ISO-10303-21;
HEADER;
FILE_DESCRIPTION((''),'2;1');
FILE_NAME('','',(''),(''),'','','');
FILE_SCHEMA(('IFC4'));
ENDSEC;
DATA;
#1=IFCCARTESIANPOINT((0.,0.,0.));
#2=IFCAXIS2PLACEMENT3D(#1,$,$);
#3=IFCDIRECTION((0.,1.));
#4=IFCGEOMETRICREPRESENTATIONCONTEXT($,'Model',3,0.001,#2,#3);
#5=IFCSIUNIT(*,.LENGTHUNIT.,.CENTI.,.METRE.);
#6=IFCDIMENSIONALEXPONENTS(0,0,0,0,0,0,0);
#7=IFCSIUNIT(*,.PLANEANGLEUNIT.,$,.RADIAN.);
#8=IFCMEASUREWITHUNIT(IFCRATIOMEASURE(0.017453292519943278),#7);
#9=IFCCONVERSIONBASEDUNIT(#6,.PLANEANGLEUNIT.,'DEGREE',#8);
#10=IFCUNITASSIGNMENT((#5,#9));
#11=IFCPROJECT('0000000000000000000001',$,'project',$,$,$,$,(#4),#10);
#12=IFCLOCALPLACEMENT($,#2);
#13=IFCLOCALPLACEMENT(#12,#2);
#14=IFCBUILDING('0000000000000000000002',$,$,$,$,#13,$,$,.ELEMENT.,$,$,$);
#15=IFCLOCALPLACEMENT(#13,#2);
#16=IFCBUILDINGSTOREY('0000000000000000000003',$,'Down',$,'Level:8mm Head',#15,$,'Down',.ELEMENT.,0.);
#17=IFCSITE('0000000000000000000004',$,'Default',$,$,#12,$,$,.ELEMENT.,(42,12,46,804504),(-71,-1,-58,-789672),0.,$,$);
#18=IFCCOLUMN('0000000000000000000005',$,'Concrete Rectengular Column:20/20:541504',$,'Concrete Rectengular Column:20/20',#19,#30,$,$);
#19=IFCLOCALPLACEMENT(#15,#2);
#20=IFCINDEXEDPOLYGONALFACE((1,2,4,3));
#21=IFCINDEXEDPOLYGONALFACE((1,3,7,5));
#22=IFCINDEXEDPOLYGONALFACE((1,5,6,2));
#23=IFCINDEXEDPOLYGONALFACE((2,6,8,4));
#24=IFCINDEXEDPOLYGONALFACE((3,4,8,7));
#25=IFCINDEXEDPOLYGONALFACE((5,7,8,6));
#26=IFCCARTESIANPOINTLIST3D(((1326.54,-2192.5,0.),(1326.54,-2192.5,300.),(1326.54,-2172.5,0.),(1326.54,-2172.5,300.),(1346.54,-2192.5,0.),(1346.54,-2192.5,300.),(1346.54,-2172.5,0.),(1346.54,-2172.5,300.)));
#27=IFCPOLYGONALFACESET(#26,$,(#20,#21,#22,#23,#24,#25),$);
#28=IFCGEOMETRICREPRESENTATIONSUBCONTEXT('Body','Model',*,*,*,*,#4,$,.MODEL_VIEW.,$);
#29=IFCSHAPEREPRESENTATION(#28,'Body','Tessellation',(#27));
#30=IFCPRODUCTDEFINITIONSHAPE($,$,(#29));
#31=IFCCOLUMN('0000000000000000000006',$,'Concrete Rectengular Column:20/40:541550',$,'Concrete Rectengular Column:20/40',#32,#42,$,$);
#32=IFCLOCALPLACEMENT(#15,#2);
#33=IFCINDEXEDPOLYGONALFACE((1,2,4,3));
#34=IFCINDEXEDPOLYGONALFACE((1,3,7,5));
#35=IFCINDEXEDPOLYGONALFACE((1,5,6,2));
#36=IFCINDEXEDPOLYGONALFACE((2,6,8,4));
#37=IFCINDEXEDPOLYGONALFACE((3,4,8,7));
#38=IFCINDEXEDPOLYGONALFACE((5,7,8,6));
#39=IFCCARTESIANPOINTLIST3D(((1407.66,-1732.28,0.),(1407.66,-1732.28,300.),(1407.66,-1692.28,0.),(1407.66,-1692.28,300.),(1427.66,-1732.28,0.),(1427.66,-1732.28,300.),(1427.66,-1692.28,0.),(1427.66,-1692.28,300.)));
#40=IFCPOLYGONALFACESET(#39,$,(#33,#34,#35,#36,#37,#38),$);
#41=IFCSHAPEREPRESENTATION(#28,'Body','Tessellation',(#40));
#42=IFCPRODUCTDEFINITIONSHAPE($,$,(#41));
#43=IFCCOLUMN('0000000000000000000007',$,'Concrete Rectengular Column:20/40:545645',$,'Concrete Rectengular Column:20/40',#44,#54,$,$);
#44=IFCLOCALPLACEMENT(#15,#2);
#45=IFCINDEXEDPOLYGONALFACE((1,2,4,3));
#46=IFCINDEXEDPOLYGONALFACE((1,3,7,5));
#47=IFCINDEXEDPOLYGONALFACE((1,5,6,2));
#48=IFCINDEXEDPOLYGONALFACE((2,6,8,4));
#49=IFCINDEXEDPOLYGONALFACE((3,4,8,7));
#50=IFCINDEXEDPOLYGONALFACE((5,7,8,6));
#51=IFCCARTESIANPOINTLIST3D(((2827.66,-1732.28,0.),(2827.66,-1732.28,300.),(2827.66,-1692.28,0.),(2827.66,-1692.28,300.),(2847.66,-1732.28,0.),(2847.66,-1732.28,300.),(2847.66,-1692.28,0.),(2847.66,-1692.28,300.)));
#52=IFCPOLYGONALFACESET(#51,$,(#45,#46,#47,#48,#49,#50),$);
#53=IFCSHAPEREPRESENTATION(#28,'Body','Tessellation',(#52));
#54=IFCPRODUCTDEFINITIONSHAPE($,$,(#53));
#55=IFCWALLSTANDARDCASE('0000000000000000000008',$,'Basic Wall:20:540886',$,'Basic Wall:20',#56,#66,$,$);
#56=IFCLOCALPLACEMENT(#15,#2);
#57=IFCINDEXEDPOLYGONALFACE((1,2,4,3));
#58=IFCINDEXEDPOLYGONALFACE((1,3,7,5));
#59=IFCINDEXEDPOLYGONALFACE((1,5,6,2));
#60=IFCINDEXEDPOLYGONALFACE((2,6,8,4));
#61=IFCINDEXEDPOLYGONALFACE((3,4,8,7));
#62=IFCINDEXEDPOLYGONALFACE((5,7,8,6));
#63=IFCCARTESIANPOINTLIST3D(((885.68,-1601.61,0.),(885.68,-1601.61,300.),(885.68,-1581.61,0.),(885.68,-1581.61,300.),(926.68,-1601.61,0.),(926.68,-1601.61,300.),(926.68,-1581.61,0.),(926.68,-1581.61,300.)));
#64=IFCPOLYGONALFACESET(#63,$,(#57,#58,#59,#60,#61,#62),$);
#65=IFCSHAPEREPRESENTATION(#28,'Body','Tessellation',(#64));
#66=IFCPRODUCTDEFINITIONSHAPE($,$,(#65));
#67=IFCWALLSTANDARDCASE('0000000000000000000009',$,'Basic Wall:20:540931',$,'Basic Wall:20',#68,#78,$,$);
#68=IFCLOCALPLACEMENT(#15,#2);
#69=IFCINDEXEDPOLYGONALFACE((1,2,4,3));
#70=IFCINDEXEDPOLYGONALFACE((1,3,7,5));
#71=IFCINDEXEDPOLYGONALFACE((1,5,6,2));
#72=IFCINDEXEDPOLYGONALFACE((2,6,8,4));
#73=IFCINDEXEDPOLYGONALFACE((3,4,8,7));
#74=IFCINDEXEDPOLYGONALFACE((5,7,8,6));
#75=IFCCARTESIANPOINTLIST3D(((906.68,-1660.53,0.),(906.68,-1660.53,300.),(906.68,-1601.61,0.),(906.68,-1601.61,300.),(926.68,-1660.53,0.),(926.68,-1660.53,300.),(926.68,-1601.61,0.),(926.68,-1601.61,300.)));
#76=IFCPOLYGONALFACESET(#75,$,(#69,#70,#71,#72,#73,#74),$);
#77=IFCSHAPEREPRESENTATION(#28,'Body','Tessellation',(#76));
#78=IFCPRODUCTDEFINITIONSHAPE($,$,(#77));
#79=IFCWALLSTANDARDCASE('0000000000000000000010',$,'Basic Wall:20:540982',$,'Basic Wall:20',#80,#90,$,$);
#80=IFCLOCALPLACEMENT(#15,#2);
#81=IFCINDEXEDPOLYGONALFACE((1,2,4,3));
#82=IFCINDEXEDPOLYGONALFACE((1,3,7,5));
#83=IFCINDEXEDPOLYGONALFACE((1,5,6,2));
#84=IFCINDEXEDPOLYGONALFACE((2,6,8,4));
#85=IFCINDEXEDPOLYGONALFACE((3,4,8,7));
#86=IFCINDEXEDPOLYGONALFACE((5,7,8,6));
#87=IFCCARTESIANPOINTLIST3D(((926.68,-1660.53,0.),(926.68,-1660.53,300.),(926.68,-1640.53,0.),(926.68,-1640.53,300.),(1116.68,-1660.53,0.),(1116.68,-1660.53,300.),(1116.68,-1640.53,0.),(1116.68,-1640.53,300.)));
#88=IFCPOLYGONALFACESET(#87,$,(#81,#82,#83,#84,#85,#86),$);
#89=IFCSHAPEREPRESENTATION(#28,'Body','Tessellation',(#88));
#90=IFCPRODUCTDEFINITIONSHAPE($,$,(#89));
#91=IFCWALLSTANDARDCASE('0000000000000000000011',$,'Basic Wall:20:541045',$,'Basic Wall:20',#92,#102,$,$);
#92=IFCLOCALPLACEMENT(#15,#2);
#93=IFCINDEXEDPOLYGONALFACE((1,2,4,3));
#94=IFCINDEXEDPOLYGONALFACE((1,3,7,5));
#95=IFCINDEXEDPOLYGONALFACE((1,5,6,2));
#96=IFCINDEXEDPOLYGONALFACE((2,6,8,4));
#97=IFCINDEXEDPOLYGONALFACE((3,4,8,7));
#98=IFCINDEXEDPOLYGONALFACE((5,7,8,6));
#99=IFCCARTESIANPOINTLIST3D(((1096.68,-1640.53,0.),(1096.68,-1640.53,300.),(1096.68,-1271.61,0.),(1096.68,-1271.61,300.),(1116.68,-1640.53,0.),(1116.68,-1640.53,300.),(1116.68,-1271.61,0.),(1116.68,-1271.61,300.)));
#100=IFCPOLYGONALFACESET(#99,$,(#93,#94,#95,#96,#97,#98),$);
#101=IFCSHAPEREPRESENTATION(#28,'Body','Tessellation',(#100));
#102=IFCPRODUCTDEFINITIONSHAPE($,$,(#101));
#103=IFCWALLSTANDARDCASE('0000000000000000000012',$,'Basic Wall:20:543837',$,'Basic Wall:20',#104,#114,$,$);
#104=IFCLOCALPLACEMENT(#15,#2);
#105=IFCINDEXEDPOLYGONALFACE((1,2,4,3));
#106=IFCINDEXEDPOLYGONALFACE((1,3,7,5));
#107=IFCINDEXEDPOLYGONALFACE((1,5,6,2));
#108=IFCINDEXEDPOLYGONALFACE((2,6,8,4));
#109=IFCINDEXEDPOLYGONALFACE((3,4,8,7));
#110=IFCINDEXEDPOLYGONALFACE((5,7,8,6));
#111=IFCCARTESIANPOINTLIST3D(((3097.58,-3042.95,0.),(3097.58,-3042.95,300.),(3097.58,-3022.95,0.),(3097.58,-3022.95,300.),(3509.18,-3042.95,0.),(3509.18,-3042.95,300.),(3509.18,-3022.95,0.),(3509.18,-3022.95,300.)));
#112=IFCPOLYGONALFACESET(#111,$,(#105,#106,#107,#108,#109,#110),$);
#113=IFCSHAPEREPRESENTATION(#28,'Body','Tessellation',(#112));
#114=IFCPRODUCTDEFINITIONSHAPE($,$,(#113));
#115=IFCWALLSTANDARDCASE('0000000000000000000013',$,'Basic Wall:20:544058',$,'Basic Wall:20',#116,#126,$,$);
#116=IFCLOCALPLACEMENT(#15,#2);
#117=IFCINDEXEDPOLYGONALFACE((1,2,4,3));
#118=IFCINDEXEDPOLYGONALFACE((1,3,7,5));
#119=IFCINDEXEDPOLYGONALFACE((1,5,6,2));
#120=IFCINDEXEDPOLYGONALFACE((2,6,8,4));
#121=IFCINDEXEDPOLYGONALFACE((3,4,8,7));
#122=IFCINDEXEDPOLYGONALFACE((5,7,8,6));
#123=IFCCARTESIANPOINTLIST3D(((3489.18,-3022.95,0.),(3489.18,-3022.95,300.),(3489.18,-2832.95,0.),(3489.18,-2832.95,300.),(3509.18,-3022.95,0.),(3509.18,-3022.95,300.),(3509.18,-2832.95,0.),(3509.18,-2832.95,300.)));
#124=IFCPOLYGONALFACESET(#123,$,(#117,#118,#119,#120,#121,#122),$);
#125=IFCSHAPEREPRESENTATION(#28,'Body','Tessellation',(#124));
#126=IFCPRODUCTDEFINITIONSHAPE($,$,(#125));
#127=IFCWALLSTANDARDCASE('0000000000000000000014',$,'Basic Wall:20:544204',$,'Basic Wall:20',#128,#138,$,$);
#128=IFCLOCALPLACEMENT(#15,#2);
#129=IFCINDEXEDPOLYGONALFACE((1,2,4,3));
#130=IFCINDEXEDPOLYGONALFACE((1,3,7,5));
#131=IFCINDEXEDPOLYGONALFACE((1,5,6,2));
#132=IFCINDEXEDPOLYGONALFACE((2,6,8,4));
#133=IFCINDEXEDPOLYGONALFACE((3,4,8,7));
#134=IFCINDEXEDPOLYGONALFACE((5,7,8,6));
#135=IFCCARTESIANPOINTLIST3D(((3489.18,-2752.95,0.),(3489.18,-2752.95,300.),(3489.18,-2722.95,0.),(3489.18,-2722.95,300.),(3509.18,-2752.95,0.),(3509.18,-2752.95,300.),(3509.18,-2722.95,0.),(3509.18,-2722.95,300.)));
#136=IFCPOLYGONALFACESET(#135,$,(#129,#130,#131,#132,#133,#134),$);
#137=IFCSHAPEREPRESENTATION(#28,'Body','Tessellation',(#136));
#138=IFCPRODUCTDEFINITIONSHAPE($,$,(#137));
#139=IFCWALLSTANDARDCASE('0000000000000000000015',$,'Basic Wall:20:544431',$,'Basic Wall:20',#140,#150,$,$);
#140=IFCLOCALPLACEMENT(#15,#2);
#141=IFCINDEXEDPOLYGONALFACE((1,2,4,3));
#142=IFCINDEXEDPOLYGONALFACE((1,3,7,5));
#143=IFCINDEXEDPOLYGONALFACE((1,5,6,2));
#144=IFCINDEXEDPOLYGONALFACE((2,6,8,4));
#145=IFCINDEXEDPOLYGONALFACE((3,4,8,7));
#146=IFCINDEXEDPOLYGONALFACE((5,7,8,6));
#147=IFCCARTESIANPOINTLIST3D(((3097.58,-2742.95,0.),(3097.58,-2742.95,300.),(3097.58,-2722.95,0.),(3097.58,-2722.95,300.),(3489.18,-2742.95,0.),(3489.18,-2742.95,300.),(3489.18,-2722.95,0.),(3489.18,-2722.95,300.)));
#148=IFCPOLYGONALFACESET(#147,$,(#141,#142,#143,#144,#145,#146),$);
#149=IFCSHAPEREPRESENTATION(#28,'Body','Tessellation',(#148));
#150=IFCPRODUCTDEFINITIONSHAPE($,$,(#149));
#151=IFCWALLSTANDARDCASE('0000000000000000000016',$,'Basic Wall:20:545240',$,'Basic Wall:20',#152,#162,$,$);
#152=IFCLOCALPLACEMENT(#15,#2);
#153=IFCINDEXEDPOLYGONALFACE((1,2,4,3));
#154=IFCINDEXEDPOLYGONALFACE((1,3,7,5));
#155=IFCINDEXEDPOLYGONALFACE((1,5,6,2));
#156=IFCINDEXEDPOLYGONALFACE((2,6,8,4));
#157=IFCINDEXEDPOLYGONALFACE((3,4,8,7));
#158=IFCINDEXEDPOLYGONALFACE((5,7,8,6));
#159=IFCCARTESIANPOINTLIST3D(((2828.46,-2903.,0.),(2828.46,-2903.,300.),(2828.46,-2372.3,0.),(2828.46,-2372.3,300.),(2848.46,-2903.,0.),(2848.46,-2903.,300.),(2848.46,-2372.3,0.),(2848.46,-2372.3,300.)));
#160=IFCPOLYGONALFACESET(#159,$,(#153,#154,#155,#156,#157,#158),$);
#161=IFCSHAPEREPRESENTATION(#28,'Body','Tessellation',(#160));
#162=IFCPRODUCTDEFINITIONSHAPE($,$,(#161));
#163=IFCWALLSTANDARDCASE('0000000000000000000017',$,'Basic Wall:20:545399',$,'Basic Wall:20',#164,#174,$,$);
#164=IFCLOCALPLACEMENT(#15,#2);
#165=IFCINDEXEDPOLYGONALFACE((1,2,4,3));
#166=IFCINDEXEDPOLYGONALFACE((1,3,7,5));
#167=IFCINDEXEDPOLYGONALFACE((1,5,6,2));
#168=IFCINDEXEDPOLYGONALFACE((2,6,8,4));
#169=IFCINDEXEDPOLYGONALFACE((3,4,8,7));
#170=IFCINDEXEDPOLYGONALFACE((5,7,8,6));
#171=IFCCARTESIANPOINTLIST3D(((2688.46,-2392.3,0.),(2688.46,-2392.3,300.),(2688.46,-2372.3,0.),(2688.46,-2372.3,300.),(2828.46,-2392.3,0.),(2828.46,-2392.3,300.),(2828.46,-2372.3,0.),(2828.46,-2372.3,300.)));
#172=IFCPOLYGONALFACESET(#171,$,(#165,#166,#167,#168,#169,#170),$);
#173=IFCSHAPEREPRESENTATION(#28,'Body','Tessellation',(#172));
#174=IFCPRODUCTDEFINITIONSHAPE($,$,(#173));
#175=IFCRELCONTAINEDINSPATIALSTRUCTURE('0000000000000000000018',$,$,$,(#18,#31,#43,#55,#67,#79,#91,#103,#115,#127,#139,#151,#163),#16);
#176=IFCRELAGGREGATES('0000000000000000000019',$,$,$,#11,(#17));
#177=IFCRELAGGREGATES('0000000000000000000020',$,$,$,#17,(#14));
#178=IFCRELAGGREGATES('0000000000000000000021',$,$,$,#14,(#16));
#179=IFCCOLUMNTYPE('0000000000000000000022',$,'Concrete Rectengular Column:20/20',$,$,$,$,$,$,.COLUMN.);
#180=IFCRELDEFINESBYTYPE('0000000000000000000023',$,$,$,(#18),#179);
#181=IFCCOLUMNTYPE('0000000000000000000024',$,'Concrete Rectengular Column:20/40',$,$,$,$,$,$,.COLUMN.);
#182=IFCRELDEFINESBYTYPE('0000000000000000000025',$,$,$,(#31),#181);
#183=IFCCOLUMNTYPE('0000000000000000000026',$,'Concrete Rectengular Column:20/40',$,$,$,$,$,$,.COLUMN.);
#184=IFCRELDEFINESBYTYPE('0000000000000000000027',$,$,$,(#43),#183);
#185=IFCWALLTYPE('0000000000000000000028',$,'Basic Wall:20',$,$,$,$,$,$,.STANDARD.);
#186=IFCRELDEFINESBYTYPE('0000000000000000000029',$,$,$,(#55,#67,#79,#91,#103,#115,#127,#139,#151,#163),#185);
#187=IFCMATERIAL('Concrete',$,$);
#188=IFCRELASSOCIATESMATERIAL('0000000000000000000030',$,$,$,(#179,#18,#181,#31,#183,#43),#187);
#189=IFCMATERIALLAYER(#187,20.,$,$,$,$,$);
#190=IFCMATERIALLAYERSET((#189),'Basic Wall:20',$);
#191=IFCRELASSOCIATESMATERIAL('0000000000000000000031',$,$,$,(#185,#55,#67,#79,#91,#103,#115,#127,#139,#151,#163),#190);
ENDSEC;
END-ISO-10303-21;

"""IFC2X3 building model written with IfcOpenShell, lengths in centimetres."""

from ifc_helpers import new_model, entity, si_unit, converted_unit, direction, frame, frame_2d, origin, origin_2d_with_axis, place, context, subcontext, project, spatial, rectangle, extrude, source, transform, mapped, material, layer, layer_set, layer_usage, type_object, type_shapes, element, save


model = new_model("IFC2X3")

# Units and contexts
model_context = context("Model", 3, precision=0.001, world=origin(), true_north=direction((0.0, 1.0)))
body_context = subcontext(model_context, "Body", "Model", "MODEL_VIEW")
ifc_project = project(units=[si_unit("LENGTHUNIT", "METRE", prefix="CENTI"), converted_unit("PLANEANGLEUNIT", "DEGREE", entity("IfcRatioMeasure", 0.017453292519943278), si_unit("PLANEANGLEUNIT", "RADIAN"), dimensions=[0, 0, 0, 0, 0, 0, 0])], contexts=[model_context])

# Site, building, storey
site_placement = place(None, origin())
site = spatial("IfcSite", under=ifc_project, at=site_placement, Name="Default", CompositionType="ELEMENT", RefLatitude=(42, 12, 46, 804504), RefLongitude=(-71, -1, -58, -789672), RefElevation=0.0)
building_placement = place(site_placement, origin())
building = spatial("IfcBuilding", under=site, at=building_placement, CompositionType="ELEMENT")
storey_placement = place(building_placement, origin())
storey = spatial("IfcBuildingStorey", under=building, at=storey_placement, Name="Down", ObjectType="Level:8mm Head", LongName="Down", CompositionType="ELEMENT", Elevation=0.0)

# Columns
ifc_material = material(Name="Concrete")
column_type_1 = type_object("IfcColumnType", Name="Concrete Rectengular Column:20/20", PredefinedType="COLUMN", material=ifc_material)
shared_shape_1 = source(origin(), body_context, "Body", "SweptSolid", [
    extrude(rectangle(XDim=20.0, YDim=20.0, at=frame_2d((0.0, 0.0), x_axis=(1.0, 0.0))), frame((1336.54, -2182.5, 0.0), z_axis=(0.0, 0.0, 1.0), x_axis=(0.0, -1.0, 0.0)), (0.0, 0.0, 1.0), 300.0),
])
type_shapes(column_type_1, [shared_shape_1])
column_1_placement = place(storey_placement, origin())
element("IfcColumn", 1, at=column_1_placement, inside=storey, type_object=column_type_1, material=ifc_material, Name="Concrete Rectengular Column:20/20:541504", ObjectType="Concrete Rectengular Column:20/20", context=body_context, shape_type="MappedRepresentation", body=[
    mapped(shared_shape_1, transform((0.0, 0.0, 0.0), scale=1.0)),
])
column_type_2 = type_object("IfcColumnType", Name="Concrete Rectengular Column:20/40", PredefinedType="COLUMN", material=ifc_material)
shared_shape_2 = source(origin(), body_context, "Body", "SweptSolid", [
    extrude(rectangle(XDim=40.0, YDim=20.0, at=frame_2d((0.0, 0.0), x_axis=(1.0, 0.0))), frame((1417.66, -1712.28, 0.0), z_axis=(0.0, 0.0, 1.0), x_axis=(0.0, -1.0, 0.0)), (0.0, 0.0, 1.0), 300.0),
])
type_shapes(column_type_2, [shared_shape_2])
column_2_placement = place(storey_placement, origin())
element("IfcColumn", 2, at=column_2_placement, inside=storey, type_object=column_type_2, material=ifc_material, Name="Concrete Rectengular Column:20/40:541550", ObjectType="Concrete Rectengular Column:20/40", context=body_context, shape_type="MappedRepresentation", body=[
    mapped(shared_shape_2, transform((0.0, 0.0, 0.0), scale=1.0)),
])
column_type_3 = type_object("IfcColumnType", Name="Concrete Rectengular Column:20/40", PredefinedType="COLUMN", material=ifc_material)
shared_shape_3 = source(origin(), body_context, "Body", "SweptSolid", [
    extrude(rectangle(XDim=40.0, YDim=20.0, at=origin_2d_with_axis()), frame((2837.66, -1712.28, 0.0), z_axis=(0.0, 0.0, 1.0), x_axis=(0.0, -1.0, 0.0)), (0.0, 0.0, 1.0), 300.0),
])
type_shapes(column_type_3, [shared_shape_3])
column_3_placement = place(storey_placement, origin())
element("IfcColumn", 3, at=column_3_placement, inside=storey, type_object=column_type_3, material=ifc_material, Name="Concrete Rectengular Column:20/40:545645", ObjectType="Concrete Rectengular Column:20/40", context=body_context, shape_type="MappedRepresentation", body=[
    mapped(shared_shape_3, transform((0.0, 0.0, 0.0), scale=1.0)),
])

# Walls
ifc_layer_1 = layer(ifc_material, 20.0)
ifc_layer_set_1 = layer_set([ifc_layer_1], Name="Basic Wall:20")
ifc_layer_usage_1 = layer_usage(ifc_layer_set_1, "AXIS2", "NEGATIVE", 10.0)
wall_type_1 = type_object("IfcWallType", Name="Basic Wall:20", PredefinedType="STANDARD", material=ifc_layer_set_1)
wall_1_placement = place(storey_placement, frame((885.68, -1591.61, 0.0)))
element("IfcWallStandardCase", 4, at=wall_1_placement, inside=storey, type_object=wall_type_1, material=ifc_layer_usage_1, Name="Basic Wall:20:540886", ObjectType="Basic Wall:20", context=body_context, shape_type="SweptSolid", body=[
    extrude(rectangle(XDim=41.0, YDim=20.0, at=frame_2d((20.5, 0.0), x_axis=(-1.0, 0.0))), origin(), (0.0, 0.0, 1.0), 300.0),
])
ifc_layer_usage_2 = layer_usage(ifc_layer_set_1, "AXIS2", "NEGATIVE", 10.0)
wall_2_placement = place(storey_placement, frame((916.68, -1601.61, 0.0), z_axis=(0.0, 0.0, 1.0), x_axis=(0.0, -1.0, 0.0)))
element("IfcWallStandardCase", 5, at=wall_2_placement, inside=storey, type_object=wall_type_1, material=ifc_layer_usage_2, Name="Basic Wall:20:540931", ObjectType="Basic Wall:20", context=body_context, shape_type="SweptSolid", body=[
    extrude(rectangle(XDim=58.92, YDim=20.0, at=frame_2d((29.46, 0.0), x_axis=(-1.0, 0.0))), origin(), (0.0, 0.0, 1.0), 300.0),
])
ifc_layer_usage_3 = layer_usage(ifc_layer_set_1, "AXIS2", "POSITIVE", -10.0)
wall_3_placement = place(storey_placement, frame((926.68, -1650.53, 0.0)))
element("IfcWallStandardCase", 6, at=wall_3_placement, inside=storey, type_object=wall_type_1, material=ifc_layer_usage_3, Name="Basic Wall:20:540982", ObjectType="Basic Wall:20", context=body_context, shape_type="SweptSolid", body=[
    extrude(rectangle(XDim=190.0, YDim=20.0, at=frame_2d((95.0, 0.0), x_axis=(-1.0, 0.0))), origin(), (0.0, 0.0, 1.0), 300.0),
])
ifc_layer_usage_4 = layer_usage(ifc_layer_set_1, "AXIS2", "POSITIVE", -10.0)
wall_4_placement = place(storey_placement, frame((1106.68, -1640.53, 0.0), z_axis=(0.0, 0.0, 1.0), x_axis=(0.0, 1.0, 0.0)))
element("IfcWallStandardCase", 7, at=wall_4_placement, inside=storey, type_object=wall_type_1, material=ifc_layer_usage_4, Name="Basic Wall:20:541045", ObjectType="Basic Wall:20", context=body_context, shape_type="SweptSolid", body=[
    extrude(rectangle(XDim=368.92, YDim=20.0, at=frame_2d((184.46, 0.0), x_axis=(-1.0, 0.0))), origin(), (0.0, 0.0, 1.0), 300.0),
])
ifc_layer_usage_5 = layer_usage(ifc_layer_set_1, "AXIS2", "NEGATIVE", 10.0)
wall_5_placement = place(storey_placement, frame((3509.18, -3032.95, 0.0), z_axis=(0.0, 0.0, 1.0), x_axis=(-1.0, 0.0, 0.0)))
element("IfcWallStandardCase", 8, at=wall_5_placement, inside=storey, type_object=wall_type_1, material=ifc_layer_usage_5, Name="Basic Wall:20:543837", ObjectType="Basic Wall:20", context=body_context, shape_type="SweptSolid", body=[
    extrude(rectangle(XDim=411.6, YDim=20.0, at=frame_2d((205.8, 0.0), x_axis=(-1.0, 0.0))), origin(), (0.0, 0.0, 1.0), 300.0),
])
ifc_layer_usage_6 = layer_usage(ifc_layer_set_1, "AXIS2", "POSITIVE", -10.0)
wall_6_placement = place(storey_placement, frame((3499.18, -3022.95, 0.0), z_axis=(0.0, 0.0, 1.0), x_axis=(0.0, 1.0, 0.0)))
element("IfcWallStandardCase", 9, at=wall_6_placement, inside=storey, type_object=wall_type_1, material=ifc_layer_usage_6, Name="Basic Wall:20:544058", ObjectType="Basic Wall:20", context=body_context, shape_type="SweptSolid", body=[
    extrude(rectangle(XDim=190.0, YDim=20.0, at=frame_2d((95.0, 0.0), x_axis=(-1.0, 0.0))), origin(), (0.0, 0.0, 1.0), 300.0),
])
ifc_layer_usage_7 = layer_usage(ifc_layer_set_1, "AXIS2", "POSITIVE", -10.0)
wall_7_placement = place(storey_placement, frame((3499.18, -2752.95, 0.0), z_axis=(0.0, 0.0, 1.0), x_axis=(0.0, 1.0, 0.0)))
element("IfcWallStandardCase", 10, at=wall_7_placement, inside=storey, type_object=wall_type_1, material=ifc_layer_usage_7, Name="Basic Wall:20:544204", ObjectType="Basic Wall:20", context=body_context, shape_type="SweptSolid", body=[
    extrude(rectangle(XDim=30.0, YDim=20.0, at=frame_2d((15.0, 0.0), x_axis=(-1.0, 0.0))), origin(), (0.0, 0.0, 1.0), 300.0),
])
ifc_layer_usage_8 = layer_usage(ifc_layer_set_1, "AXIS2", "POSITIVE", -10.0)
wall_8_placement = place(storey_placement, frame((3489.18, -2732.95, 0.0), z_axis=(0.0, 0.0, 1.0), x_axis=(-1.0, 0.0, 0.0)))
element("IfcWallStandardCase", 11, at=wall_8_placement, inside=storey, type_object=wall_type_1, material=ifc_layer_usage_8, Name="Basic Wall:20:544431", ObjectType="Basic Wall:20", context=body_context, shape_type="SweptSolid", body=[
    extrude(rectangle(XDim=391.6, YDim=20.0, at=frame_2d((195.8, 0.0), x_axis=(-1.0, 0.0))), origin(), (0.0, 0.0, 1.0), 300.0),
])
ifc_layer_usage_9 = layer_usage(ifc_layer_set_1, "AXIS2", "POSITIVE", -10.0)
wall_9_placement = place(storey_placement, frame((2838.46, -2903.0, 0.0), z_axis=(0.0, 0.0, 1.0), x_axis=(0.0, 1.0, 0.0)))
element("IfcWallStandardCase", 12, at=wall_9_placement, inside=storey, type_object=wall_type_1, material=ifc_layer_usage_9, Name="Basic Wall:20:545240", ObjectType="Basic Wall:20", context=body_context, shape_type="SweptSolid", body=[
    extrude(rectangle(XDim=530.71, YDim=20.0, at=frame_2d((265.35, 0.0), x_axis=(-1.0, 0.0))), origin(), (0.0, 0.0, 1.0), 300.0),
])
ifc_layer_usage_10 = layer_usage(ifc_layer_set_1, "AXIS2", "POSITIVE", -10.0)
wall_10_placement = place(storey_placement, frame((2828.46, -2382.3, 0.0), z_axis=(0.0, 0.0, 1.0), x_axis=(-1.0, 0.0, 0.0)))
element("IfcWallStandardCase", 13, at=wall_10_placement, inside=storey, type_object=wall_type_1, material=ifc_layer_usage_10, Name="Basic Wall:20:545399", ObjectType="Basic Wall:20", context=body_context, shape_type="SweptSolid", body=[
    extrude(rectangle(XDim=140.0, YDim=20.0, at=frame_2d((70.0, 0.0), x_axis=(-1.0, 0.0))), origin(), (0.0, 0.0, 1.0), 300.0),
])

save(model, "model.ifc")
